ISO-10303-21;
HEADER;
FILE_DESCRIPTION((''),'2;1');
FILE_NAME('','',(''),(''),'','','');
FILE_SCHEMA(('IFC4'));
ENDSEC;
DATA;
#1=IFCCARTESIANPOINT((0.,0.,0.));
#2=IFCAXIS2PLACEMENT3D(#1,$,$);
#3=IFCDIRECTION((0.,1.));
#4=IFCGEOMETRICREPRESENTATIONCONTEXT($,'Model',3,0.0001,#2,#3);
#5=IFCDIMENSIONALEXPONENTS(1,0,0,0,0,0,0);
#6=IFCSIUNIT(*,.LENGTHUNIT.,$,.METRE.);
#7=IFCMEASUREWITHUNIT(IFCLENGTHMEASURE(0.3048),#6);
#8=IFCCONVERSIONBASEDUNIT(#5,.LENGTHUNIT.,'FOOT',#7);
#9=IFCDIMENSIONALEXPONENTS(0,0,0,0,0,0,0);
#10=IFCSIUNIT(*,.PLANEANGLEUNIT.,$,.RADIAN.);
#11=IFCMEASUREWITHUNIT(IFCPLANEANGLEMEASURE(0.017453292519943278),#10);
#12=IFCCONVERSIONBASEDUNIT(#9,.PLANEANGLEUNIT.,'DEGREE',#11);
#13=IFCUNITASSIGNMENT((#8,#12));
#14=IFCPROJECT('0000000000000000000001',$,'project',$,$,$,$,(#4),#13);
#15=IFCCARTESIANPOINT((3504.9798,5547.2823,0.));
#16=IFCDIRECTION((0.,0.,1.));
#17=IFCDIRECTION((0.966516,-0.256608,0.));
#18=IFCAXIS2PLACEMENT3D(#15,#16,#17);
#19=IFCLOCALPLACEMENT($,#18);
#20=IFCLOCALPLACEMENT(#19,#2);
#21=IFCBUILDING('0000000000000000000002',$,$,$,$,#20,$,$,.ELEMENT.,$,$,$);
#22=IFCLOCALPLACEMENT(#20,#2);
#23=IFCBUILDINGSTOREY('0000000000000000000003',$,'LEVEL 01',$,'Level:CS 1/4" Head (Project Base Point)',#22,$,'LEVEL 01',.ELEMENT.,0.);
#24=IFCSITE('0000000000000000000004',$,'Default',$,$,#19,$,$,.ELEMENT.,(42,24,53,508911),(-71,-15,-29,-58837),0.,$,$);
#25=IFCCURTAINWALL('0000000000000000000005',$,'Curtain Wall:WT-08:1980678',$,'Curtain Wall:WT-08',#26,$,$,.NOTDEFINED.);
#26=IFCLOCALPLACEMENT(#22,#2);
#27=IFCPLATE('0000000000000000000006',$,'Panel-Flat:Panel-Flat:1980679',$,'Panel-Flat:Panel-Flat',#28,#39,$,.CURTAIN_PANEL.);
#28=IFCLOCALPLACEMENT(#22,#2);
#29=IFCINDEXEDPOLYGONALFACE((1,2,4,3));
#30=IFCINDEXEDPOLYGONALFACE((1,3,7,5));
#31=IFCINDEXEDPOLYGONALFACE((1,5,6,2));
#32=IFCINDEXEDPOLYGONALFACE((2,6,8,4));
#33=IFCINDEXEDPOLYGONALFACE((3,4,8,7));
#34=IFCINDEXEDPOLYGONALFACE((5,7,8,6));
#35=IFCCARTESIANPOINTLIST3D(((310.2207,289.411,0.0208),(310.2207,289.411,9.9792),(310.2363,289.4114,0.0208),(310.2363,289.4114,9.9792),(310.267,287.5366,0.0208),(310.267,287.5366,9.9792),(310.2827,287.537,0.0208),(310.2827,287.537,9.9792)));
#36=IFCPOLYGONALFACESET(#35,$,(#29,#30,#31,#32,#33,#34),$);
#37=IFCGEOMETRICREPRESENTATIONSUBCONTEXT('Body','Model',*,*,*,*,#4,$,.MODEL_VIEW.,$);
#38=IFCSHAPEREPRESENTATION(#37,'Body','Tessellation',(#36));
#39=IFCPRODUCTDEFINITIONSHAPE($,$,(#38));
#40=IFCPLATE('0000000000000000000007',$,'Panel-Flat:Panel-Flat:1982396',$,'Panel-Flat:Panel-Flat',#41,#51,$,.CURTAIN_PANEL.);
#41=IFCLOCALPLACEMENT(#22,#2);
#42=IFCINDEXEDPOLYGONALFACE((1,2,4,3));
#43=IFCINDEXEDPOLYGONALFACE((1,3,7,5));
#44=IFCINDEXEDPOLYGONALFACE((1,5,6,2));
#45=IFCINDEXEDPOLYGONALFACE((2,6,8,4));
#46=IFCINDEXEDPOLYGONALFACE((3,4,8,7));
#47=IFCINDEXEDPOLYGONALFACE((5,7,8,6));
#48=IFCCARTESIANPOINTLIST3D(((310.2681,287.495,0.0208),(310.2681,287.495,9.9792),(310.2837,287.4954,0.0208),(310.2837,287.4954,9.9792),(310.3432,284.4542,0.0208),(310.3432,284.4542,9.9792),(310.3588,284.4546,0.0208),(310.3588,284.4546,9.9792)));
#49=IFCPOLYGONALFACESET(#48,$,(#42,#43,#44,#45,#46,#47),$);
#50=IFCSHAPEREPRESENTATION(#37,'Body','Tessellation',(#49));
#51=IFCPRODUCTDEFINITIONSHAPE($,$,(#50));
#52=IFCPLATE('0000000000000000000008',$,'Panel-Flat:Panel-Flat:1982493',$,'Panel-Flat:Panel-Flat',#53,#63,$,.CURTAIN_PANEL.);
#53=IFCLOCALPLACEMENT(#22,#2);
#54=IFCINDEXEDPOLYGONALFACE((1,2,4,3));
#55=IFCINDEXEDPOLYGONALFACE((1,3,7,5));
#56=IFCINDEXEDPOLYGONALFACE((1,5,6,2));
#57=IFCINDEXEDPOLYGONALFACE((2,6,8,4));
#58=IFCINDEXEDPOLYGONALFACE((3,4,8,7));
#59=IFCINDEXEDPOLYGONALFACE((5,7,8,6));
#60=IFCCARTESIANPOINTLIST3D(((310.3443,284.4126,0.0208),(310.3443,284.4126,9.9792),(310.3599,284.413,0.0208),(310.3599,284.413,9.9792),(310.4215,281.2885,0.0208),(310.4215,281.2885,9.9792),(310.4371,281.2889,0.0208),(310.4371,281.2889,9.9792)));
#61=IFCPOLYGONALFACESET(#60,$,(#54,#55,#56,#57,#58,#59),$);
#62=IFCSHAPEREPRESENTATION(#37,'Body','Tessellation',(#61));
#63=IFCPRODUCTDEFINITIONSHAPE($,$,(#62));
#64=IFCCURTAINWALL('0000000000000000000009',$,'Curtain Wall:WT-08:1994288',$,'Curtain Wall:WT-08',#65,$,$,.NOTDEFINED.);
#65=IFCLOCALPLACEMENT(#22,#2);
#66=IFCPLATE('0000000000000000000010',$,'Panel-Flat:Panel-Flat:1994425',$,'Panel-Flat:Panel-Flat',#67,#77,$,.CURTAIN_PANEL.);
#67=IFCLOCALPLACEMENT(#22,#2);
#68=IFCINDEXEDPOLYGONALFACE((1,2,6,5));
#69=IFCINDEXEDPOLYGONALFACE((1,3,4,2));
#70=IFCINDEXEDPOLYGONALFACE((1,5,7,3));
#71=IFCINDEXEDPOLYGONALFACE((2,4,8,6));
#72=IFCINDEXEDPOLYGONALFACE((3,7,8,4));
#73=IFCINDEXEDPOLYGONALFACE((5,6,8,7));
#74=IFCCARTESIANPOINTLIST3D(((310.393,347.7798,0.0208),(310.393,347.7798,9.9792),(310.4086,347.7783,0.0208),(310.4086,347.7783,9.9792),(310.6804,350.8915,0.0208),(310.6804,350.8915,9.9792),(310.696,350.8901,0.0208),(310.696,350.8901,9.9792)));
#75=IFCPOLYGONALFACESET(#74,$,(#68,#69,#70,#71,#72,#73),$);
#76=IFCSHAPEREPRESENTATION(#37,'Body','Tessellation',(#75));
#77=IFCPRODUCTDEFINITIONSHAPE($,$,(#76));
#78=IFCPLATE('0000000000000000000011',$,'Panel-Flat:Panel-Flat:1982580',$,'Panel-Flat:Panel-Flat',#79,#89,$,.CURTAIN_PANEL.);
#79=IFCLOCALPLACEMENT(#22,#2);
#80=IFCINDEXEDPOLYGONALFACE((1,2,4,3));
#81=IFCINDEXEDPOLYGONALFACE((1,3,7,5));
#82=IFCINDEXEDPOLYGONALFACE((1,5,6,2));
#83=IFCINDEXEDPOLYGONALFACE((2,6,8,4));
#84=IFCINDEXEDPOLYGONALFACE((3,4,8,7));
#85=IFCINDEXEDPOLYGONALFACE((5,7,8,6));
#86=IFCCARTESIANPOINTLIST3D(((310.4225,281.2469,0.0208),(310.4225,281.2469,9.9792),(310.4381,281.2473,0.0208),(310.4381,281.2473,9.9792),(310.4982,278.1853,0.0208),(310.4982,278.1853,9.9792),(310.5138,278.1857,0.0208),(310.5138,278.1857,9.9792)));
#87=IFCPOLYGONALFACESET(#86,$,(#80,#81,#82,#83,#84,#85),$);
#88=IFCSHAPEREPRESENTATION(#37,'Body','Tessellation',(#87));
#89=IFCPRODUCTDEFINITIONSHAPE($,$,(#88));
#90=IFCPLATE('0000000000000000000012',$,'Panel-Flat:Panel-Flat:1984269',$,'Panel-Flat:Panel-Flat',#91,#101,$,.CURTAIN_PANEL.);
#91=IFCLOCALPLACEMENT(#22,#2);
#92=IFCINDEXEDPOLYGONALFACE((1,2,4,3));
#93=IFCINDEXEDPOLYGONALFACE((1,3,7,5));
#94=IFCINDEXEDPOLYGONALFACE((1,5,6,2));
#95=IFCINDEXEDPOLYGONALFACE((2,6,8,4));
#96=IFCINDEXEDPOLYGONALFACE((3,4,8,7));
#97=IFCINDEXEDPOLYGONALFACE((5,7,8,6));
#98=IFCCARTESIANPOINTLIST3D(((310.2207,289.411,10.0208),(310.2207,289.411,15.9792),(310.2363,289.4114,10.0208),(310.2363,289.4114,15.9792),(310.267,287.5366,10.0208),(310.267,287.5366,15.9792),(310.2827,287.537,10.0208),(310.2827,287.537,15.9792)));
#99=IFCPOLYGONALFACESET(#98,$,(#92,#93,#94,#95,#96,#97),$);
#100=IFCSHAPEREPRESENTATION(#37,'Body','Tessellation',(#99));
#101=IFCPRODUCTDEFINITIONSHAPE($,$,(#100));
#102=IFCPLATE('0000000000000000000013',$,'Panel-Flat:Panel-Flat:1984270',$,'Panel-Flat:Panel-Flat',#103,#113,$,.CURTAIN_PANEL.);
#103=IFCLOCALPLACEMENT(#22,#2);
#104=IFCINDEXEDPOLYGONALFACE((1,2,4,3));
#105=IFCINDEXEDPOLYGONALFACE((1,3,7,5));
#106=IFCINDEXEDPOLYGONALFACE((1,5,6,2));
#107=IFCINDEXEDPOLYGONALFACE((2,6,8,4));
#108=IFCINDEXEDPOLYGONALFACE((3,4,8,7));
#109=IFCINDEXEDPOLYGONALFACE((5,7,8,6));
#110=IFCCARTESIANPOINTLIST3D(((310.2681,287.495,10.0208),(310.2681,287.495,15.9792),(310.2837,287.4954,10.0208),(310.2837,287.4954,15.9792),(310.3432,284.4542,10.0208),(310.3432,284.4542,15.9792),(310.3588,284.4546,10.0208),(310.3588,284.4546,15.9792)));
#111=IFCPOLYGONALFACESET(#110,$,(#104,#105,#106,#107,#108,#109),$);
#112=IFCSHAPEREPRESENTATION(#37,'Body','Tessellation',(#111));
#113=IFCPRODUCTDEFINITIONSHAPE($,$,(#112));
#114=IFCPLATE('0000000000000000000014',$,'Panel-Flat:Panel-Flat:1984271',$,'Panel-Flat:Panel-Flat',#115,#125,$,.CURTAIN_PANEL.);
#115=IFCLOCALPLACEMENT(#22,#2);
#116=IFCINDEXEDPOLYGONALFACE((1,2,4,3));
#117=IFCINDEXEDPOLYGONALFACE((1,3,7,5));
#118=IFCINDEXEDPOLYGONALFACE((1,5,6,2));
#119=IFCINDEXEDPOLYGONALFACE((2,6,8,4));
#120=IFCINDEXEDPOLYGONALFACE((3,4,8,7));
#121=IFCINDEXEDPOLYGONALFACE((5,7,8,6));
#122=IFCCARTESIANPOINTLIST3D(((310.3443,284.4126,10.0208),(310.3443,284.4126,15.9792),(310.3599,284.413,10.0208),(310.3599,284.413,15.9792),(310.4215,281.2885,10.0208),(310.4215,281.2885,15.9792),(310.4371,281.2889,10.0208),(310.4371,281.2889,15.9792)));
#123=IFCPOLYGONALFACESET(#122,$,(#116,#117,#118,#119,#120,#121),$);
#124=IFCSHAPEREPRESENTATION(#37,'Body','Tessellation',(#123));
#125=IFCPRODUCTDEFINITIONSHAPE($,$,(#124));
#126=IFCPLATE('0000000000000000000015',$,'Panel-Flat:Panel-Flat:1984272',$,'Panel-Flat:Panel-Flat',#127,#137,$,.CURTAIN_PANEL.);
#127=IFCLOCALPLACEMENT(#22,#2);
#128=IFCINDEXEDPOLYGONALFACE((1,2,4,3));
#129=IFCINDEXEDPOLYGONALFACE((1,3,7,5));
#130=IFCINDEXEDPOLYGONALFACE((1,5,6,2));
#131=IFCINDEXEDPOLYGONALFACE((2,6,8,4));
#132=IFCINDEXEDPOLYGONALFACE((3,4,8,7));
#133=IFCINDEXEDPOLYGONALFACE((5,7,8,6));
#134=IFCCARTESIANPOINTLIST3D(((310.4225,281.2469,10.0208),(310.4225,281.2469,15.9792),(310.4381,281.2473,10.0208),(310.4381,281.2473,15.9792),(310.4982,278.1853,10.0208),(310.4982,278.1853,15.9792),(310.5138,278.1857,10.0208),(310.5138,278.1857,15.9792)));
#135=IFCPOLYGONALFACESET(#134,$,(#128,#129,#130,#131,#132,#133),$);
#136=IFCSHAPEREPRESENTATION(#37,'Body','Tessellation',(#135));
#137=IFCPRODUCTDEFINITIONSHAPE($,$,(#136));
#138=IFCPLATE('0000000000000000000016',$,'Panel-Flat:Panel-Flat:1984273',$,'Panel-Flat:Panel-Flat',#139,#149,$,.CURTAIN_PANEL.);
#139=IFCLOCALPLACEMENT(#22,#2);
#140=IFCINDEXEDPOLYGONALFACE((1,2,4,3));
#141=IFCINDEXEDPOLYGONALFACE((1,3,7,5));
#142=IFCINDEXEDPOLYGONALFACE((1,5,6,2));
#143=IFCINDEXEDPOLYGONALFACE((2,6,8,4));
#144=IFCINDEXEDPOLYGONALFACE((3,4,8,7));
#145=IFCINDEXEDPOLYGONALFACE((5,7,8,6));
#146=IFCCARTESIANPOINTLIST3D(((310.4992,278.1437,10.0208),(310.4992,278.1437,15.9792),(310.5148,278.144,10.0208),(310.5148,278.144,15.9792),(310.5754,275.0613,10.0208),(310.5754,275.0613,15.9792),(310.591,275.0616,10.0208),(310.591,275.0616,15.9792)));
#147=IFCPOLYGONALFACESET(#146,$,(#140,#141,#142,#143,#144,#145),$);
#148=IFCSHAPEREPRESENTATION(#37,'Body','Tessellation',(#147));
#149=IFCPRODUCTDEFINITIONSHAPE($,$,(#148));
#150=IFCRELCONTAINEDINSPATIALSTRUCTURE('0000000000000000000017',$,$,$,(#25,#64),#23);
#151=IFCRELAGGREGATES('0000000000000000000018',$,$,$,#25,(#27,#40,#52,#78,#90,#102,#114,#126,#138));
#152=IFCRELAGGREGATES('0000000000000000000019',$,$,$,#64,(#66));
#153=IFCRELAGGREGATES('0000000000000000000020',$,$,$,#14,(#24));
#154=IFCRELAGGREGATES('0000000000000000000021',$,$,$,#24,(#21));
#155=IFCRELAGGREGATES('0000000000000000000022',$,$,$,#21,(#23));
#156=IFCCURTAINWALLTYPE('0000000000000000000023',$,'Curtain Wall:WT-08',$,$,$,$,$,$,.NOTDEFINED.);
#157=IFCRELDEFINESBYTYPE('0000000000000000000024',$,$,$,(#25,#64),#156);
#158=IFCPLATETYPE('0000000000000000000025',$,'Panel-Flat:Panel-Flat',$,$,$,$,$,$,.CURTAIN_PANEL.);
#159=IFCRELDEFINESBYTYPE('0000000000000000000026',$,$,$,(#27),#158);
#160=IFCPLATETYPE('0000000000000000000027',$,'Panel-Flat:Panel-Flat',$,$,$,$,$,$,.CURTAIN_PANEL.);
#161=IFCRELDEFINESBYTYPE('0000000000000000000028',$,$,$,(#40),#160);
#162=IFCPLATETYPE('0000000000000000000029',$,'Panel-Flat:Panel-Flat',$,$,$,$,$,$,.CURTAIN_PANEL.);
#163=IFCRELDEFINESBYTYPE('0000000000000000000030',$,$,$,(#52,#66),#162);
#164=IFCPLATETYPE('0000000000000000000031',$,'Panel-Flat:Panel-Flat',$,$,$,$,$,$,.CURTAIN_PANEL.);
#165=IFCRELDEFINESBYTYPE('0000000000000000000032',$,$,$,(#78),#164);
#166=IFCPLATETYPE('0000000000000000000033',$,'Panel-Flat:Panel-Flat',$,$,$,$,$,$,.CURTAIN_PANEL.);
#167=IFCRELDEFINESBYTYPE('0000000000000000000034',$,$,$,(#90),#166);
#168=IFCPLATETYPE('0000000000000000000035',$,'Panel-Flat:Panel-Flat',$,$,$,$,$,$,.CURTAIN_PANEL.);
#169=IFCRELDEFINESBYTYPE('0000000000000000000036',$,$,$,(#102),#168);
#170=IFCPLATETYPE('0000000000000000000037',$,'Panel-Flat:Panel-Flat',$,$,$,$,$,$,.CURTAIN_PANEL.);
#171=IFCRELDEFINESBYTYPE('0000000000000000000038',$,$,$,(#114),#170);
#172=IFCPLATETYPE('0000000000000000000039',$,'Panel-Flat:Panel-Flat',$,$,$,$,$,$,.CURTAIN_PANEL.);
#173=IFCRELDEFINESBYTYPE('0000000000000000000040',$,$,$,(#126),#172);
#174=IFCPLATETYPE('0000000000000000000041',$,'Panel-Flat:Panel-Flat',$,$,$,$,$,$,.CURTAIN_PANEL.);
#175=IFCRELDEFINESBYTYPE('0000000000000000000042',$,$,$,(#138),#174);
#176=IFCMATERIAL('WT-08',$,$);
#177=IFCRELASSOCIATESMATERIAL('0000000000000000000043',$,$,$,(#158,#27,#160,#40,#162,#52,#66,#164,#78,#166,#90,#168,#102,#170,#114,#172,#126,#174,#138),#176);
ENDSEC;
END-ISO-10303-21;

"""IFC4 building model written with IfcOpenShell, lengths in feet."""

from ifc_helpers import new_model, entity, si_unit, converted_unit, direction, frame, origin, place, context, subcontext, project, spatial, indexed_curve, outline, extrude, source, transform, mapped, material, type_object, type_shapes, element, aggregate, save


model = new_model("IFC4")

# Units and contexts
model_context = context("Model", 3, precision=0.0001, world=origin(), true_north=direction((0.0, 1.0)))
body_context = subcontext(model_context, "Body", "Model", "MODEL_VIEW")
ifc_project = project(units=[converted_unit("LENGTHUNIT", "FOOT", entity("IfcLengthMeasure", 0.3048), si_unit("LENGTHUNIT", "METRE"), dimensions=[1, 0, 0, 0, 0, 0, 0]), converted_unit("PLANEANGLEUNIT", "DEGREE", entity("IfcPlaneAngleMeasure", 0.017453292519943278), si_unit("PLANEANGLEUNIT", "RADIAN"), dimensions=[0, 0, 0, 0, 0, 0, 0])], contexts=[model_context])

# Site, building, storey
site_placement = place(None, frame((3504.9798, 5547.2823, 0.0), z_axis=(0.0, 0.0, 1.0), x_axis=(0.966516, -0.256608, 0.0)))
site = spatial("IfcSite", under=ifc_project, at=site_placement, Name="Default", CompositionType="ELEMENT", RefLatitude=(42, 24, 53, 508911), RefLongitude=(-71, -15, -29, -58837), RefElevation=0.0)
building_placement = place(site_placement, origin())
building = spatial("IfcBuilding", under=site, at=building_placement, CompositionType="ELEMENT")
storey_placement = place(building_placement, origin())
storey = spatial("IfcBuildingStorey", under=building, at=storey_placement, Name="LEVEL 01", ObjectType="Level:CS 1/4\" Head (Project Base Point)", LongName="LEVEL 01", CompositionType="ELEMENT", Elevation=0.0)

# Curtain wall, plates
curtain_wall_type_1 = type_object("IfcCurtainWallType", Name="Curtain Wall:WT-08", PredefinedType="NOTDEFINED")
curtain_wall_1_placement = place(storey_placement, origin())
curtain_wall_1 = element("IfcCurtainWall", 1, at=curtain_wall_1_placement, inside=storey, type_object=curtain_wall_type_1, Name="Curtain Wall:WT-08:1980678", ObjectType="Curtain Wall:WT-08", PredefinedType="NOTDEFINED")
ifc_material_1 = material(Name="WT-08")
plate_type_1 = type_object("IfcPlateType", Name="Panel-Flat:Panel-Flat", PredefinedType="CURTAIN_PANEL", material=ifc_material_1)
shared_shape_1 = source(origin(), body_context, "Body", "SweptSolid", [
    extrude(outline(indexed_curve([(-0.0078, -0.9375), (0.0078, -0.9375), (0.0078, 0.9375), (-0.0078, 0.9375), (-0.0078, -0.9375)], self_intersect=False)), frame((0.9375, 0.0078, 0.0), z_axis=(0.0, 0.0, 1.0), x_axis=(0.0, -1.0, 0.0)), (0.0, 0.0, 1.0), 9.9583),
])
type_shapes(plate_type_1, [shared_shape_1])
plate_1_placement = place(curtain_wall_1_placement, frame((310.2207, 289.411, 0.0208), z_axis=(0.0, 0.0, 1.0), x_axis=(0.024711, -0.999695, 0.0)))
plate_1 = element("IfcPlate", 2, at=plate_1_placement, type_object=plate_type_1, material=ifc_material_1, Name="Panel-Flat:Panel-Flat:1980679", ObjectType="Panel-Flat:Panel-Flat", PredefinedType="CURTAIN_PANEL", context=body_context, shape_type="MappedRepresentation", body=[
    mapped(shared_shape_1, transform((0.0, 0.0, 0.0), scale=1.0)),
])
plate_type_2 = type_object("IfcPlateType", Name="Panel-Flat:Panel-Flat", PredefinedType="CURTAIN_PANEL", material=ifc_material_1)
shared_shape_2 = source(origin(), body_context, "Body", "SweptSolid", [
    extrude(outline(indexed_curve([(-0.0078, -1.5208), (0.0078, -1.5208), (0.0078, 1.5208), (-0.0078, 1.5208), (-0.0078, -1.5208)], self_intersect=False)), frame((1.5208, 0.0078, 0.0), z_axis=(0.0, 0.0, 1.0), x_axis=(0.0, -1.0, 0.0)), (0.0, 0.0, 1.0), 9.9583),
])
type_shapes(plate_type_2, [shared_shape_2])
plate_2_placement = place(curtain_wall_1_placement, frame((310.2681, 287.495, 0.0208), z_axis=(0.0, 0.0, 1.0), x_axis=(0.024711, -0.999695, 0.0)))
plate_2 = element("IfcPlate", 3, at=plate_2_placement, type_object=plate_type_2, material=ifc_material_1, Name="Panel-Flat:Panel-Flat:1982396", ObjectType="Panel-Flat:Panel-Flat", PredefinedType="CURTAIN_PANEL", context=body_context, shape_type="MappedRepresentation", body=[
    mapped(shared_shape_2, transform((0.0, 0.0, 0.0), scale=1.0)),
])
plate_type_3 = type_object("IfcPlateType", Name="Panel-Flat:Panel-Flat", PredefinedType="CURTAIN_PANEL", material=ifc_material_1)
shared_shape_3 = source(origin(), body_context, "Body", "SweptSolid", [
    extrude(outline(indexed_curve([(-0.0078, -1.5625), (0.0078, -1.5625), (0.0078, 1.5625), (-0.0078, 1.5625), (-0.0078, -1.5625)], self_intersect=False)), frame((1.5625, 0.0078, 0.0), z_axis=(0.0, 0.0, 1.0), x_axis=(0.0, -1.0, 0.0)), (0.0, 0.0, 1.0), 9.9583),
])
type_shapes(plate_type_3, [shared_shape_3])
plate_3_placement = place(curtain_wall_1_placement, frame((310.3443, 284.4126, 0.0208), z_axis=(0.0, 0.0, 1.0), x_axis=(0.024711, -0.999695, 0.0)))
plate_3 = element("IfcPlate", 4, at=plate_3_placement, type_object=plate_type_3, material=ifc_material_1, Name="Panel-Flat:Panel-Flat:1982493", ObjectType="Panel-Flat:Panel-Flat", PredefinedType="CURTAIN_PANEL", context=body_context, shape_type="MappedRepresentation", body=[
    mapped(shared_shape_3, transform((0.0, 0.0, 0.0), scale=1.0)),
])

# Curtain wall, plate
curtain_wall_2_placement = place(storey_placement, origin())
curtain_wall_2 = element("IfcCurtainWall", 5, at=curtain_wall_2_placement, inside=storey, type_object=curtain_wall_type_1, Name="Curtain Wall:WT-08:1994288", ObjectType="Curtain Wall:WT-08", PredefinedType="NOTDEFINED")
plate_4_placement = place(curtain_wall_2_placement, frame((310.6804, 350.8915, 0.0208), z_axis=(0.0, 0.0, 1.0), x_axis=(-0.091962, -0.995763, 0.0)))
plate_4 = element("IfcPlate", 6, at=plate_4_placement, type_object=plate_type_3, material=ifc_material_1, Name="Panel-Flat:Panel-Flat:1994425", ObjectType="Panel-Flat:Panel-Flat", PredefinedType="CURTAIN_PANEL", context=body_context, shape_type="MappedRepresentation", body=[
    mapped(shared_shape_3, transform((0.0, 0.0, 0.0), scale=1.0)),
])

# Plates
plate_type_4 = type_object("IfcPlateType", Name="Panel-Flat:Panel-Flat", PredefinedType="CURTAIN_PANEL", material=ifc_material_1)
shared_shape_4 = source(origin(), body_context, "Body", "SweptSolid", [
    extrude(outline(indexed_curve([(-0.0078, -1.5313), (0.0078, -1.5313), (0.0078, 1.5313), (-0.0078, 1.5313), (-0.0078, -1.5313)], self_intersect=False)), frame((1.5313, 0.0078, 0.0), z_axis=(0.0, 0.0, 1.0), x_axis=(0.0, -1.0, 0.0)), (0.0, 0.0, 1.0), 9.9583),
])
type_shapes(plate_type_4, [shared_shape_4])
plate_5_placement = place(curtain_wall_1_placement, frame((310.4225, 281.2469, 0.0208), z_axis=(0.0, 0.0, 1.0), x_axis=(0.024711, -0.999695, 0.0)))
plate_5 = element("IfcPlate", 7, at=plate_5_placement, type_object=plate_type_4, material=ifc_material_1, Name="Panel-Flat:Panel-Flat:1982580", ObjectType="Panel-Flat:Panel-Flat", PredefinedType="CURTAIN_PANEL", context=body_context, shape_type="MappedRepresentation", body=[
    mapped(shared_shape_4, transform((0.0, 0.0, 0.0), scale=1.0)),
])
plate_type_5 = type_object("IfcPlateType", Name="Panel-Flat:Panel-Flat", PredefinedType="CURTAIN_PANEL", material=ifc_material_1)
shared_shape_5 = source(origin(), body_context, "Body", "SweptSolid", [
    extrude(outline(indexed_curve([(-0.0078, -0.9375), (0.0078, -0.9375), (0.0078, 0.9375), (-0.0078, 0.9375), (-0.0078, -0.9375)], self_intersect=False)), frame((0.9375, 0.0078, 0.0), z_axis=(0.0, 0.0, 1.0), x_axis=(0.0, -1.0, 0.0)), (0.0, 0.0, 1.0), 5.9583),
])
type_shapes(plate_type_5, [shared_shape_5])
plate_6_placement = place(curtain_wall_1_placement, frame((310.2207, 289.411, 10.0208), z_axis=(0.0, 0.0, 1.0), x_axis=(0.024711, -0.999695, 0.0)))
plate_6 = element("IfcPlate", 8, at=plate_6_placement, type_object=plate_type_5, material=ifc_material_1, Name="Panel-Flat:Panel-Flat:1984269", ObjectType="Panel-Flat:Panel-Flat", PredefinedType="CURTAIN_PANEL", context=body_context, shape_type="MappedRepresentation", body=[
    mapped(shared_shape_5, transform((0.0, 0.0, 0.0), scale=1.0)),
])
plate_type_6 = type_object("IfcPlateType", Name="Panel-Flat:Panel-Flat", PredefinedType="CURTAIN_PANEL", material=ifc_material_1)
shared_shape_6 = source(origin(), body_context, "Body", "SweptSolid", [
    extrude(outline(indexed_curve([(-0.0078, -1.5208), (0.0078, -1.5208), (0.0078, 1.5208), (-0.0078, 1.5208), (-0.0078, -1.5208)], self_intersect=False)), frame((1.5208, 0.0078, 0.0), z_axis=(0.0, 0.0, 1.0), x_axis=(0.0, -1.0, 0.0)), (0.0, 0.0, 1.0), 5.9583),
])
type_shapes(plate_type_6, [shared_shape_6])
plate_7_placement = place(curtain_wall_1_placement, frame((310.2681, 287.495, 10.0208), z_axis=(0.0, 0.0, 1.0), x_axis=(0.024711, -0.999695, 0.0)))
plate_7 = element("IfcPlate", 9, at=plate_7_placement, type_object=plate_type_6, material=ifc_material_1, Name="Panel-Flat:Panel-Flat:1984270", ObjectType="Panel-Flat:Panel-Flat", PredefinedType="CURTAIN_PANEL", context=body_context, shape_type="MappedRepresentation", body=[
    mapped(shared_shape_6, transform((0.0, 0.0, 0.0), scale=1.0)),
])
plate_type_7 = type_object("IfcPlateType", Name="Panel-Flat:Panel-Flat", PredefinedType="CURTAIN_PANEL", material=ifc_material_1)
shared_shape_7 = source(origin(), body_context, "Body", "SweptSolid", [
    extrude(outline(indexed_curve([(-0.0078, -1.5625), (0.0078, -1.5625), (0.0078, 1.5625), (-0.0078, 1.5625), (-0.0078, -1.5625)], self_intersect=False)), frame((1.5625, 0.0078, 0.0), z_axis=(0.0, 0.0, 1.0), x_axis=(0.0, -1.0, 0.0)), (0.0, 0.0, 1.0), 5.9583),
])
type_shapes(plate_type_7, [shared_shape_7])
plate_8_placement = place(curtain_wall_1_placement, frame((310.3443, 284.4126, 10.0208), z_axis=(0.0, 0.0, 1.0), x_axis=(0.024711, -0.999695, 0.0)))
plate_8 = element("IfcPlate", 10, at=plate_8_placement, type_object=plate_type_7, material=ifc_material_1, Name="Panel-Flat:Panel-Flat:1984271", ObjectType="Panel-Flat:Panel-Flat", PredefinedType="CURTAIN_PANEL", context=body_context, shape_type="MappedRepresentation", body=[
    mapped(shared_shape_7, transform((0.0, 0.0, 0.0), scale=1.0)),
])
plate_type_8 = type_object("IfcPlateType", Name="Panel-Flat:Panel-Flat", PredefinedType="CURTAIN_PANEL", material=ifc_material_1)
shared_shape_8 = source(origin(), body_context, "Body", "SweptSolid", [
    extrude(outline(indexed_curve([(-0.0078, -1.5313), (0.0078, -1.5313), (0.0078, 1.5313), (-0.0078, 1.5313), (-0.0078, -1.5313)], self_intersect=False)), frame((1.5313, 0.0078, 0.0), z_axis=(0.0, 0.0, 1.0), x_axis=(0.0, -1.0, 0.0)), (0.0, 0.0, 1.0), 5.9583),
])
type_shapes(plate_type_8, [shared_shape_8])
plate_9_placement = place(curtain_wall_1_placement, frame((310.4225, 281.2469, 10.0208), z_axis=(0.0, 0.0, 1.0), x_axis=(0.024711, -0.999695, 0.0)))
plate_9 = element("IfcPlate", 11, at=plate_9_placement, type_object=plate_type_8, material=ifc_material_1, Name="Panel-Flat:Panel-Flat:1984272", ObjectType="Panel-Flat:Panel-Flat", PredefinedType="CURTAIN_PANEL", context=body_context, shape_type="MappedRepresentation", body=[
    mapped(shared_shape_8, transform((0.0, 0.0, 0.0), scale=1.0)),
])
plate_type_9 = type_object("IfcPlateType", Name="Panel-Flat:Panel-Flat", PredefinedType="CURTAIN_PANEL", material=ifc_material_1)
shared_shape_9 = source(origin(), body_context, "Body", "SweptSolid", [
    extrude(outline(indexed_curve([(-0.0078, -1.5417), (0.0078, -1.5417), (0.0078, 1.5417), (-0.0078, 1.5417), (-0.0078, -1.5417)], self_intersect=False)), frame((1.5417, 0.0078, 0.0), z_axis=(0.0, 0.0, 1.0), x_axis=(0.0, -1.0, 0.0)), (0.0, 0.0, 1.0), 5.9583),
])
type_shapes(plate_type_9, [shared_shape_9])
plate_10_placement = place(curtain_wall_1_placement, frame((310.4992, 278.1437, 10.0208), z_axis=(0.0, 0.0, 1.0), x_axis=(0.024711, -0.999695, 0.0)))
plate_10 = element("IfcPlate", 12, at=plate_10_placement, type_object=plate_type_9, material=ifc_material_1, Name="Panel-Flat:Panel-Flat:1984273", ObjectType="Panel-Flat:Panel-Flat", PredefinedType="CURTAIN_PANEL", context=body_context, shape_type="MappedRepresentation", body=[
    mapped(shared_shape_9, transform((0.0, 0.0, 0.0), scale=1.0)),
])
aggregate(curtain_wall_1, [plate_1, plate_2, plate_3, plate_5, plate_6, plate_7, plate_8, plate_9, plate_10])

aggregate(curtain_wall_2, [plate_4])

save(model, "model.ifc")
